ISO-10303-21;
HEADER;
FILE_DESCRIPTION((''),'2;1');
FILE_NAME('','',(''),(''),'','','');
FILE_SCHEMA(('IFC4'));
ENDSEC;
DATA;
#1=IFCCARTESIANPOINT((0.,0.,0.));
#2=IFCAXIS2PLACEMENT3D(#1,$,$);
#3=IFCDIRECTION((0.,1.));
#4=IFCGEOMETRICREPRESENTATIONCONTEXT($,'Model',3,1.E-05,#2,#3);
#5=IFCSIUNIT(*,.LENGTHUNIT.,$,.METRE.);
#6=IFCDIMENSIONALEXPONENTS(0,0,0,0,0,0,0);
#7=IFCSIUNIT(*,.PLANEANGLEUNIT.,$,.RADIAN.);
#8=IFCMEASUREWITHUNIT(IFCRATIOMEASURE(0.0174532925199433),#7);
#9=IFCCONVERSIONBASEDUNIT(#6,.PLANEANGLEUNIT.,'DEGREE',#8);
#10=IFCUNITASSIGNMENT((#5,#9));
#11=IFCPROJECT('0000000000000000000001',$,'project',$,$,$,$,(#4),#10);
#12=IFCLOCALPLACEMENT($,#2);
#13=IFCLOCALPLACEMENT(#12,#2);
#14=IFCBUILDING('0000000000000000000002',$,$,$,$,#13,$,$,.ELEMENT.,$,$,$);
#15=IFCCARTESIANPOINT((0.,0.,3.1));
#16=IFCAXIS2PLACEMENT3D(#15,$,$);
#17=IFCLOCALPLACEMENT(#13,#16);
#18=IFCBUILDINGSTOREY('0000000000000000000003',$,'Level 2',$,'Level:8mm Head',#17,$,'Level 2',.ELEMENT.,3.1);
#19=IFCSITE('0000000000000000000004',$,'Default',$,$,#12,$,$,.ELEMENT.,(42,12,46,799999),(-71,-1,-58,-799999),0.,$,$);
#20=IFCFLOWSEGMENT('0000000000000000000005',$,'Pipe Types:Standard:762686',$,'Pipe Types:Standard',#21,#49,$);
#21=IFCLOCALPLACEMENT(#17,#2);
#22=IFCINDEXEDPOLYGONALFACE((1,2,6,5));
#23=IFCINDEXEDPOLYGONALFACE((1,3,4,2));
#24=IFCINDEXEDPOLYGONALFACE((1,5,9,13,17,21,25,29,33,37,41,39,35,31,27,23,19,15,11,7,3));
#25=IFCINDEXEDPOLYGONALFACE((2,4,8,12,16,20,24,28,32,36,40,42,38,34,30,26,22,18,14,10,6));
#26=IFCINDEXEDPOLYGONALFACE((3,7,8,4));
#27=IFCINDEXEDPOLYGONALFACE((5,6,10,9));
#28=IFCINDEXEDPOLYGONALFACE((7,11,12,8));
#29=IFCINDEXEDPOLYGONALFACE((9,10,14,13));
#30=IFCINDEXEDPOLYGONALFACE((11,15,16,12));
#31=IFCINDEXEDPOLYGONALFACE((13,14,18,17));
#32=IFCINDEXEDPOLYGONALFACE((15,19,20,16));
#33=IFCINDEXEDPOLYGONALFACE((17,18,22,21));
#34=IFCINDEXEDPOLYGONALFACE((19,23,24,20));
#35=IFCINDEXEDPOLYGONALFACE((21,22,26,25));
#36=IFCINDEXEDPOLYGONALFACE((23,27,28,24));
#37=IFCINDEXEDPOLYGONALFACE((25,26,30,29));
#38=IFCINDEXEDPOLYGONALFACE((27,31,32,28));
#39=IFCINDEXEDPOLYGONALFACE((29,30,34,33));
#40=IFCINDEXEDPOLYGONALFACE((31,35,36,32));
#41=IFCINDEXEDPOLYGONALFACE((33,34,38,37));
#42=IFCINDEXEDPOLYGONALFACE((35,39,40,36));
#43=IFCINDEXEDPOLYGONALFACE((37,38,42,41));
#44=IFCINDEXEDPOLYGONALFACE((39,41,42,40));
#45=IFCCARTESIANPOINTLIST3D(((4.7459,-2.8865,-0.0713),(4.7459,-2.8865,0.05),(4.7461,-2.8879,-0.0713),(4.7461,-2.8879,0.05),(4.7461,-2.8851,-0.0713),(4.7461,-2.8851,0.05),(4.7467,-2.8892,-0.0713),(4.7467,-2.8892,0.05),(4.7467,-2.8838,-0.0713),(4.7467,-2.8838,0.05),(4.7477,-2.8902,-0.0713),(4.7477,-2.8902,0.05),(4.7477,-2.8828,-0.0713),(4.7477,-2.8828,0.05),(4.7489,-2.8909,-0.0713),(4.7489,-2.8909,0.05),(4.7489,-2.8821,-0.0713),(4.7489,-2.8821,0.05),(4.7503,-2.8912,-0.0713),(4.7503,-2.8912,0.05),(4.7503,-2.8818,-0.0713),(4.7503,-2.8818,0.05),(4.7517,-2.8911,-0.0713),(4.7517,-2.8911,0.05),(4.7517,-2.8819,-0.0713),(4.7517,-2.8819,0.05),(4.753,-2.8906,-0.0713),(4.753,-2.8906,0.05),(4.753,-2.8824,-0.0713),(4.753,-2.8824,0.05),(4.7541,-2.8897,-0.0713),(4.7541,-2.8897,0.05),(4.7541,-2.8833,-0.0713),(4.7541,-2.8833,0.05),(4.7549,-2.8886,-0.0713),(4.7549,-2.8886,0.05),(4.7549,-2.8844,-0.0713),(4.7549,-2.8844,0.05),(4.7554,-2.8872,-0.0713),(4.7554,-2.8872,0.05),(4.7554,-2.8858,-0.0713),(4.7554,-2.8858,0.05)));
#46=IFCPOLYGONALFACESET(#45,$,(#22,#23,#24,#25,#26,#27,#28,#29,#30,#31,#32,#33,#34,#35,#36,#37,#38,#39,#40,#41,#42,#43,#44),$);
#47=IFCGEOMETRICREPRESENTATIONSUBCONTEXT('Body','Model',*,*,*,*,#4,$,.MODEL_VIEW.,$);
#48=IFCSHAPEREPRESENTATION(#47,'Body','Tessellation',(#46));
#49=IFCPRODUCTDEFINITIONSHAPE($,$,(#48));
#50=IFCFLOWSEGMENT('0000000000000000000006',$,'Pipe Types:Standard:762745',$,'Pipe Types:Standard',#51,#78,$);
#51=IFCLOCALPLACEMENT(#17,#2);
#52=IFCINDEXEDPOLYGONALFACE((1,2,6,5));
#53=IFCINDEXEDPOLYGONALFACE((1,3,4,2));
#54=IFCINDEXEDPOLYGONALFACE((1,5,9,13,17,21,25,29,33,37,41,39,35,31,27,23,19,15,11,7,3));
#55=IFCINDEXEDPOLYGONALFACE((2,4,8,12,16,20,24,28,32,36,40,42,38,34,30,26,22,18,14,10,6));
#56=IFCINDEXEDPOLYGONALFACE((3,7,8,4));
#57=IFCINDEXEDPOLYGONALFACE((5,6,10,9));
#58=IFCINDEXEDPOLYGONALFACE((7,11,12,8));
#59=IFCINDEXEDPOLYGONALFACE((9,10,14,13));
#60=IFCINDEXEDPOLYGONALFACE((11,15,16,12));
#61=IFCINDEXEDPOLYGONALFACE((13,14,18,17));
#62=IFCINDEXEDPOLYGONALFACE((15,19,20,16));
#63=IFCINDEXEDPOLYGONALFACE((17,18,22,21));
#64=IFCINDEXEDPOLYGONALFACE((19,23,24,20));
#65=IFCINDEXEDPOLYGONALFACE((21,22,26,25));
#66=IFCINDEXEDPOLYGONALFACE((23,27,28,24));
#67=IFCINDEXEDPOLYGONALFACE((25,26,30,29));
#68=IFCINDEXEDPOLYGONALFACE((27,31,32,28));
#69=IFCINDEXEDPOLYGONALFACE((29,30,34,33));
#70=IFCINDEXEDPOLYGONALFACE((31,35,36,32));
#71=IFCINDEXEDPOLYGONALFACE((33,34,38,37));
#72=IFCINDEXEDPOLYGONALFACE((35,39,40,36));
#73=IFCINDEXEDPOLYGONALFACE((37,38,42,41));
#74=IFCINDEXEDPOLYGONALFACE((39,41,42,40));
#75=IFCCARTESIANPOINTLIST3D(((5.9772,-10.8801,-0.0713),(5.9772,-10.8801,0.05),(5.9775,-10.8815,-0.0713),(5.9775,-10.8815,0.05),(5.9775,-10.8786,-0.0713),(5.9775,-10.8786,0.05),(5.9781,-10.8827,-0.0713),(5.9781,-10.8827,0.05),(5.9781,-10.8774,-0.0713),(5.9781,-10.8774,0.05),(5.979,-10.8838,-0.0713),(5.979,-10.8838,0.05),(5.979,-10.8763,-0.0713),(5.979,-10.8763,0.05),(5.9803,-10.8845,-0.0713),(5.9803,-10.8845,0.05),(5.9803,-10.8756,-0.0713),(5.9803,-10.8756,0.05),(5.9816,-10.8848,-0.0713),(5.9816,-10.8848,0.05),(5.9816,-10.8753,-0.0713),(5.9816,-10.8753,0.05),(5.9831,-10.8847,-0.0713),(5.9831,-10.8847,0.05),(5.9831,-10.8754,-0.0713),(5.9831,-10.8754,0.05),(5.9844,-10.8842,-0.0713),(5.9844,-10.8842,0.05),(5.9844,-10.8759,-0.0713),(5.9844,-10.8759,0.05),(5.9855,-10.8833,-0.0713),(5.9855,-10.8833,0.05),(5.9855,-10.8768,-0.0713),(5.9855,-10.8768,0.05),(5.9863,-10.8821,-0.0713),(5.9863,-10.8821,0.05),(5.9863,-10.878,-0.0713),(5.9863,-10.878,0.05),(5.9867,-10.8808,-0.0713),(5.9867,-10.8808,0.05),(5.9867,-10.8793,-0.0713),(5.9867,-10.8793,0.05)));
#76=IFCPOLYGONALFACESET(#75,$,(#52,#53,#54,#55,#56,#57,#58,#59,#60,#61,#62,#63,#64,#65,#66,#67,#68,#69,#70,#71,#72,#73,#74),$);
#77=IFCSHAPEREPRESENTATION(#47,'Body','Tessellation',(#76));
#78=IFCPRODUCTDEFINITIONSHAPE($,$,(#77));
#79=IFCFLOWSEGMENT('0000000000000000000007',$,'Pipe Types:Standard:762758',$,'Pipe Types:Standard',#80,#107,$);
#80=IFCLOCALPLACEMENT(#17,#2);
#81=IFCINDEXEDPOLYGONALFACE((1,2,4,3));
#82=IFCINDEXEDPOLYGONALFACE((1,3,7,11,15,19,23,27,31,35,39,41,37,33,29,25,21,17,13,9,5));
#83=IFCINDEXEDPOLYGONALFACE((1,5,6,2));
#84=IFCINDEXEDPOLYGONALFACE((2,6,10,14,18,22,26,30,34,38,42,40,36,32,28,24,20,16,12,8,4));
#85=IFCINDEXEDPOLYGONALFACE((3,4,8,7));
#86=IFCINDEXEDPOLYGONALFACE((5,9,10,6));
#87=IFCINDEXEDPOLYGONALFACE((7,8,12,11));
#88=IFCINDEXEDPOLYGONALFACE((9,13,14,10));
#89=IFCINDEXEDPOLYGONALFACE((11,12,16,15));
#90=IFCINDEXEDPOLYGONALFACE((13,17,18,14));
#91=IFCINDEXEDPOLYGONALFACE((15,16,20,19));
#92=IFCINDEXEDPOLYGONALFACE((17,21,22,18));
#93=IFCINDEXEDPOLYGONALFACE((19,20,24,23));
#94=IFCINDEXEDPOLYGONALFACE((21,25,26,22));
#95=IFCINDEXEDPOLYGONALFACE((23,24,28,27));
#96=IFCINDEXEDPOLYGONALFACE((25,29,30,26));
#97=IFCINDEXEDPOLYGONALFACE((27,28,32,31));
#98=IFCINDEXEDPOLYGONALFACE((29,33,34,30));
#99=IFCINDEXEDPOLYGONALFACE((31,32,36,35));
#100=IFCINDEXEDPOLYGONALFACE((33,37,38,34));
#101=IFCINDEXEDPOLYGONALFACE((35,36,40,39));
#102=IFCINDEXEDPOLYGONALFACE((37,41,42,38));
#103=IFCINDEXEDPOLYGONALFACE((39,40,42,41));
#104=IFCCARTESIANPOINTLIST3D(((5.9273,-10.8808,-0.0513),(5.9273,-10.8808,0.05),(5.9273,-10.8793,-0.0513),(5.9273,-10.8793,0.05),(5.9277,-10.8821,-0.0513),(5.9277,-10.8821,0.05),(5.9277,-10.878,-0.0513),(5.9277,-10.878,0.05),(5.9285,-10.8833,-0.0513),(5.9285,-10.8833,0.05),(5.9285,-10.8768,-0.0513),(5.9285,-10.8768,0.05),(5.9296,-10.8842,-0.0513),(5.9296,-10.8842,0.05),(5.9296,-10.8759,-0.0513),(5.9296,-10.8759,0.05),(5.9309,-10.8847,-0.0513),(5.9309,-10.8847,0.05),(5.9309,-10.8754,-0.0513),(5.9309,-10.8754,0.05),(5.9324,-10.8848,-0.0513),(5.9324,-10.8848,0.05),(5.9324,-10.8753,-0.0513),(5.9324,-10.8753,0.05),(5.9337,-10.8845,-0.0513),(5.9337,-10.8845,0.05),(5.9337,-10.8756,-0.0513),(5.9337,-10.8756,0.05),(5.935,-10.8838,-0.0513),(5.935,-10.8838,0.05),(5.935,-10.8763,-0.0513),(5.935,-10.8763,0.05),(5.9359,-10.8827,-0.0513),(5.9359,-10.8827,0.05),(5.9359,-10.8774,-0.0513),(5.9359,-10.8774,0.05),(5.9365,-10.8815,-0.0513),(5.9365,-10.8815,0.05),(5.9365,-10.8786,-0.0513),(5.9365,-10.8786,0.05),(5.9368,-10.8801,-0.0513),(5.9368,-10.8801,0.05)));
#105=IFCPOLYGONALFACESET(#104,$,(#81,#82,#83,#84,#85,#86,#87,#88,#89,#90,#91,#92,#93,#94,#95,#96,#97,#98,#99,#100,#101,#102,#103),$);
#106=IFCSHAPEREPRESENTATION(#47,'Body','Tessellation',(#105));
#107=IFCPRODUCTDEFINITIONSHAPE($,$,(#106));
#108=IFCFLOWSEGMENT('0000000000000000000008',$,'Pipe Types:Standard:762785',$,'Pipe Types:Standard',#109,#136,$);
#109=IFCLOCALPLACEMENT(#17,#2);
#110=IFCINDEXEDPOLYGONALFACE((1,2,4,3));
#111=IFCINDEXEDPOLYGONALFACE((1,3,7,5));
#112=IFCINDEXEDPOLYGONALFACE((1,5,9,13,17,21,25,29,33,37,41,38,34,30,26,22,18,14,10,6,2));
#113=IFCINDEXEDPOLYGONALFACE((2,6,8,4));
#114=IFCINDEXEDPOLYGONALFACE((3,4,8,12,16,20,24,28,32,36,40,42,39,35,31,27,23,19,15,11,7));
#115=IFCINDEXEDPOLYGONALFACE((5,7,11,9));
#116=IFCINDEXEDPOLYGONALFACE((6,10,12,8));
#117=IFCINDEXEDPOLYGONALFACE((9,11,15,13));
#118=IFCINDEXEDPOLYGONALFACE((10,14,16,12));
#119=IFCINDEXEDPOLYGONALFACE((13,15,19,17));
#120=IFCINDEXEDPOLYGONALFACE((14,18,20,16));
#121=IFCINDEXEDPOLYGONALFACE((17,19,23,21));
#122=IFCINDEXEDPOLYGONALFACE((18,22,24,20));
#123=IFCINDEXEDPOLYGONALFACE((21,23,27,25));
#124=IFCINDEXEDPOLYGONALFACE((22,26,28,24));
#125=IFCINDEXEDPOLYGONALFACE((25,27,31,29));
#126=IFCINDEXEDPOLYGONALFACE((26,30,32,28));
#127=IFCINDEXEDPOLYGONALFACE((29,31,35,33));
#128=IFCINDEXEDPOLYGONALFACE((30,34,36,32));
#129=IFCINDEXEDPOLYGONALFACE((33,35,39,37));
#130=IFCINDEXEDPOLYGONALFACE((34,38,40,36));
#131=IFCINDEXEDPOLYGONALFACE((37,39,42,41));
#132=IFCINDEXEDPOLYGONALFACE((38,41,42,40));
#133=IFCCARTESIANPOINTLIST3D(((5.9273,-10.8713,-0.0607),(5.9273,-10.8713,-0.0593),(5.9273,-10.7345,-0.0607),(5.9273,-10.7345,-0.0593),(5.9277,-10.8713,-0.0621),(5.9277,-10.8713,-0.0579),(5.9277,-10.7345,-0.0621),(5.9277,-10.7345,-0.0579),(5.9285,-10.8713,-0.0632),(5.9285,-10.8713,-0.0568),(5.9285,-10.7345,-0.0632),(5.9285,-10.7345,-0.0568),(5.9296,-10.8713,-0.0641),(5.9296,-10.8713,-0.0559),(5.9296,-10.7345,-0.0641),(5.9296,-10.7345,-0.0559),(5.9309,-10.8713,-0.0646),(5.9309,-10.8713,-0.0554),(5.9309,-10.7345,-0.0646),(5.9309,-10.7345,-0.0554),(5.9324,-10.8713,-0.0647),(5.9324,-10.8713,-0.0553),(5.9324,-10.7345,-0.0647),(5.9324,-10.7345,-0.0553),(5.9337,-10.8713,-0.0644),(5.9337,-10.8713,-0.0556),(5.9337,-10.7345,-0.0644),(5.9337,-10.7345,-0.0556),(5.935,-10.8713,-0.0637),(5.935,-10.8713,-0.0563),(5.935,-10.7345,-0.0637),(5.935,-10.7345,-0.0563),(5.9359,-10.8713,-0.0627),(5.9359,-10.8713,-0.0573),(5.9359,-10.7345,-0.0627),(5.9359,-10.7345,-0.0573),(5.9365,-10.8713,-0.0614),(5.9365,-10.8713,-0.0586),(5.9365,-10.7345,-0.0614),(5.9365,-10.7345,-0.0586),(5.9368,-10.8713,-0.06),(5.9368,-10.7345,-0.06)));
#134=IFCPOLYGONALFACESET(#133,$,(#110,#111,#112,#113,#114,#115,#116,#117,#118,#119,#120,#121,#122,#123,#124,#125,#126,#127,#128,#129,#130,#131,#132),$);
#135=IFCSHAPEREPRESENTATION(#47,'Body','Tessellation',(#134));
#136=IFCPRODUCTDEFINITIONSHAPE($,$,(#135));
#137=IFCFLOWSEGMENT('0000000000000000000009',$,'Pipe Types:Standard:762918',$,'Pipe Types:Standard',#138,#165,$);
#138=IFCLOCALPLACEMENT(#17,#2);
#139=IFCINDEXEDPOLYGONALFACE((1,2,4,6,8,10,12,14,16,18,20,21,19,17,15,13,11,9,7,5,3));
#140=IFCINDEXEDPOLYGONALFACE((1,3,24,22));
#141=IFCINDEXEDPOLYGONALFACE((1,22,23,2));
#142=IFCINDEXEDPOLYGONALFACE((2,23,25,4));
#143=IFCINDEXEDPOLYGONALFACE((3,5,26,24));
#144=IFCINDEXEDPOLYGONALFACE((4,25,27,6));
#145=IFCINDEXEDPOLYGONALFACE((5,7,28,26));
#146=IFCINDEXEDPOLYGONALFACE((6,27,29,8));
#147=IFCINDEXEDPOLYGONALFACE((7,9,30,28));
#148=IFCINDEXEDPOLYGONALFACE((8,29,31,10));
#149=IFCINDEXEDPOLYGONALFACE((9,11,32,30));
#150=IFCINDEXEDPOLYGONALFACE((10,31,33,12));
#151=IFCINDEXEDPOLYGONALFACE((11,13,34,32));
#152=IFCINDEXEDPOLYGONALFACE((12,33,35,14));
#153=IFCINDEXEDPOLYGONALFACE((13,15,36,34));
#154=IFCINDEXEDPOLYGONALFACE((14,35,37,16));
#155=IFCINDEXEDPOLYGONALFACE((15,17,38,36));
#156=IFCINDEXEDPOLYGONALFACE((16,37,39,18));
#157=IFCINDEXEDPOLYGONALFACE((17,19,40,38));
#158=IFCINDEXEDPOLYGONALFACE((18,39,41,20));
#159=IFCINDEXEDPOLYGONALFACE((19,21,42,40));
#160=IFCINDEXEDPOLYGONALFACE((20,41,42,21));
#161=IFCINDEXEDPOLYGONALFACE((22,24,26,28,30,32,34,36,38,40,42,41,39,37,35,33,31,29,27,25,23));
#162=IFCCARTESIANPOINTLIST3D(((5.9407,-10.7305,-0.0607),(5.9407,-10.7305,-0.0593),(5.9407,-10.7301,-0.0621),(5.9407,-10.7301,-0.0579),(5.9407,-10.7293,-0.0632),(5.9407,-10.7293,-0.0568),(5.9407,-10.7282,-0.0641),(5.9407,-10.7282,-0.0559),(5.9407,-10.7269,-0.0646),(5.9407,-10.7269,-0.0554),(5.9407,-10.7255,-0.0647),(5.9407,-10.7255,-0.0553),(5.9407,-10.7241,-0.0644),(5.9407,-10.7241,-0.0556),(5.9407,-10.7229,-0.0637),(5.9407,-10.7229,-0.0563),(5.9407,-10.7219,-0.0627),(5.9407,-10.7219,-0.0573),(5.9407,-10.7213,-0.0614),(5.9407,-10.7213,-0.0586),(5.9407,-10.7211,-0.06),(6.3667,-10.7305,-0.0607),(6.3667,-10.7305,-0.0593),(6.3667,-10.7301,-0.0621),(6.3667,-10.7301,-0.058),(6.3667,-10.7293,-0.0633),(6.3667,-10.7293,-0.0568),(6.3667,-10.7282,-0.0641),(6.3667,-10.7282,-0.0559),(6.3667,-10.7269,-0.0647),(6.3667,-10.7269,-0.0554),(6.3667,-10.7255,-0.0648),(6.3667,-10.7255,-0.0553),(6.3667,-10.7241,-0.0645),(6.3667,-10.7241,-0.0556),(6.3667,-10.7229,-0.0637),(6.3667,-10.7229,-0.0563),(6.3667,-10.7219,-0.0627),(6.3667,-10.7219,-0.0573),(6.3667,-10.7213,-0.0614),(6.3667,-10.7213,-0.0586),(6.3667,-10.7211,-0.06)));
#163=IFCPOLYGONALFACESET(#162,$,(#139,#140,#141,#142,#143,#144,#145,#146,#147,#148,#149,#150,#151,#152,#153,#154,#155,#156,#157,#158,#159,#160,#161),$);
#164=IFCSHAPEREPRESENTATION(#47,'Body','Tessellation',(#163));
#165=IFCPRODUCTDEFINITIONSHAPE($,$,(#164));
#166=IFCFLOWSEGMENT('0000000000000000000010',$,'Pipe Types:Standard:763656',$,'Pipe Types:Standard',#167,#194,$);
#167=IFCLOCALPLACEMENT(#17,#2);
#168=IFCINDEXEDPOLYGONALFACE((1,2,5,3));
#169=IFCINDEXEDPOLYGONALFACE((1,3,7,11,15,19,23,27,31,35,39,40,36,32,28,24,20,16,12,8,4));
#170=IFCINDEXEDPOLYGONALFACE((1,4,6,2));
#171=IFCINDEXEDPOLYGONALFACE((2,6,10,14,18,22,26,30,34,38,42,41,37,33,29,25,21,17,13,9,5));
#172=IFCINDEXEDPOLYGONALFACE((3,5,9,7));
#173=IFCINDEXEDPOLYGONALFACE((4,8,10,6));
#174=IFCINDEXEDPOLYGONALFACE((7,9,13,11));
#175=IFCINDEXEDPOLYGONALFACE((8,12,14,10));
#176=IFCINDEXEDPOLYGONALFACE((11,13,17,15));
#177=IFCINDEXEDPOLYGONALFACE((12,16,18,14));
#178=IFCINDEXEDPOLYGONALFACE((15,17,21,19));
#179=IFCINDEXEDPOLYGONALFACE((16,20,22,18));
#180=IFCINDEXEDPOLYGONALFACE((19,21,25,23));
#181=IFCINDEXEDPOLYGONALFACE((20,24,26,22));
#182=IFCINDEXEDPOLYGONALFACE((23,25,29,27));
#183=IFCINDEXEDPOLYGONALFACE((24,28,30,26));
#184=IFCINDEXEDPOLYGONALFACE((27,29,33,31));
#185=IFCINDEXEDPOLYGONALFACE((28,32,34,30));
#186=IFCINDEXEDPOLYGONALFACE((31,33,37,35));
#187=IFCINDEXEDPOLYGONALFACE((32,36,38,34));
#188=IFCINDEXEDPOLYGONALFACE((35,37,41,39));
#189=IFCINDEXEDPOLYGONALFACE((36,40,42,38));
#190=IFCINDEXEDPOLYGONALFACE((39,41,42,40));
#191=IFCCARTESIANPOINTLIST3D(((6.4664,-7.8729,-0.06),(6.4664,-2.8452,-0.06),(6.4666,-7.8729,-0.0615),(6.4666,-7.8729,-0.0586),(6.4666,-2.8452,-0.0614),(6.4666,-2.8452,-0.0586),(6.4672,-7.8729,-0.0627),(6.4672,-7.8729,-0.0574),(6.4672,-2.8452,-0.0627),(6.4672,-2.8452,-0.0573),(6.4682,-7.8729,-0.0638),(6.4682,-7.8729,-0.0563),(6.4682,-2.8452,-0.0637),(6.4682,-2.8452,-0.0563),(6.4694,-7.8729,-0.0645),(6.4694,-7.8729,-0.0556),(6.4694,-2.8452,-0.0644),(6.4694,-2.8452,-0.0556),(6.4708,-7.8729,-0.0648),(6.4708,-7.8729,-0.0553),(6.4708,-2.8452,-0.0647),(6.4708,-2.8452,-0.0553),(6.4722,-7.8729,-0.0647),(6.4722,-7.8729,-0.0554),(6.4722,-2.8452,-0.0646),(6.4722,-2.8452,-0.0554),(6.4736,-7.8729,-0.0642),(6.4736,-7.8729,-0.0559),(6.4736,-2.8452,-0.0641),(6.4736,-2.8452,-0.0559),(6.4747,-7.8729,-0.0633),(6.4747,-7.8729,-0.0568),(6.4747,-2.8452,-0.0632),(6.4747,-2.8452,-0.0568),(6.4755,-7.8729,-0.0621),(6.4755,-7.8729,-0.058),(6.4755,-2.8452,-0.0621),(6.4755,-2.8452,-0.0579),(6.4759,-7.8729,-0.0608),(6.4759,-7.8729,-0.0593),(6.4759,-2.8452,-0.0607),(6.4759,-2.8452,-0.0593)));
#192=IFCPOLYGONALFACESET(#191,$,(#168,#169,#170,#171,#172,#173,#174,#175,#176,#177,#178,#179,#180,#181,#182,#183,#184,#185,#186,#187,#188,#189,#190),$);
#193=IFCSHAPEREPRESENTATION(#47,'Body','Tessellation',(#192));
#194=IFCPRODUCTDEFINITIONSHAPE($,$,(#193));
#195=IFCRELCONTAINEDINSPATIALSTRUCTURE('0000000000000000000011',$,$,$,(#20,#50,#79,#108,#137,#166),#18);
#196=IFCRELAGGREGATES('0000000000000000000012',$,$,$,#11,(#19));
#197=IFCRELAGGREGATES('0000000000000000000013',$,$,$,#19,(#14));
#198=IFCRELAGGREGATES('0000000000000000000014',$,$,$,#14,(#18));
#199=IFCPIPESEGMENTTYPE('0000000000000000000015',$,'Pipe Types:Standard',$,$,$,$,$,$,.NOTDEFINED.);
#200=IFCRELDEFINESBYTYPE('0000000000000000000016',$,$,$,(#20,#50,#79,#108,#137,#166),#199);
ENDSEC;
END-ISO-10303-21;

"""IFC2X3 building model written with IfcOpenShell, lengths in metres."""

from ifc_helpers import new_model, entity, si_unit, converted_unit, direction, frame, frame_2d, origin, origin_2d_with_axis, place, context, subcontext, project, spatial, circle, extrude, type_object, element, save


model = new_model("IFC2X3")

# Units and contexts
model_context = context("Model", 3, precision=1e-05, world=origin(), true_north=direction((0.0, 1.0)))
body_context = subcontext(model_context, "Body", "Model", "MODEL_VIEW")
ifc_project = project(units=[si_unit("LENGTHUNIT", "METRE"), converted_unit("PLANEANGLEUNIT", "DEGREE", entity("IfcRatioMeasure", 0.0174532925199433), si_unit("PLANEANGLEUNIT", "RADIAN"), dimensions=[0, 0, 0, 0, 0, 0, 0])], contexts=[model_context])

# Site, building, storey
site_placement = place(None, origin())
site = spatial("IfcSite", under=ifc_project, at=site_placement, Name="Default", CompositionType="ELEMENT", RefLatitude=(42, 12, 46, 799999), RefLongitude=(-71, -1, -58, -799999), RefElevation=0.0)
building_placement = place(site_placement, origin())
building = spatial("IfcBuilding", under=site, at=building_placement, CompositionType="ELEMENT")
storey_placement = place(building_placement, frame((0.0, 0.0, 3.1)))
storey = spatial("IfcBuildingStorey", under=building, at=storey_placement, Name="Level 2", ObjectType="Level:8mm Head", LongName="Level 2", CompositionType="ELEMENT", Elevation=3.1)

# Flow segments
pipe_segment_type = type_object("IfcPipeSegmentType", Name="Pipe Types:Standard", PredefinedType="NOTDEFINED")
flow_segment_1_placement = place(storey_placement, origin())
element("IfcFlowSegment", 1, at=flow_segment_1_placement, inside=storey, type_object=pipe_segment_type, Name="Pipe Types:Standard:762686", ObjectType="Pipe Types:Standard", context=body_context, shape_type="SweptSolid", body=[
    extrude(circle(Radius=0.0048, at=frame_2d((0.0, 0.0), x_axis=(1.0, 0.0))), frame((4.7506, -2.8865, -0.0713), z_axis=(0.0, 0.0, 1.0), x_axis=(-1.0, 0.0, 0.0)), (0.0, 0.0, 1.0), 0.1213),
])
flow_segment_2_placement = place(storey_placement, origin())
element("IfcFlowSegment", 2, at=flow_segment_2_placement, inside=storey, type_object=pipe_segment_type, Name="Pipe Types:Standard:762745", ObjectType="Pipe Types:Standard", context=body_context, shape_type="SweptSolid", body=[
    extrude(circle(Radius=0.0048, at=origin_2d_with_axis()), frame((5.982, -10.8801, -0.0713), z_axis=(0.0, 0.0, 1.0), x_axis=(-1.0, 0.0, 0.0)), (0.0, 0.0, 1.0), 0.1213),
])
flow_segment_3_placement = place(storey_placement, origin())
element("IfcFlowSegment", 3, at=flow_segment_3_placement, inside=storey, type_object=pipe_segment_type, Name="Pipe Types:Standard:762758", ObjectType="Pipe Types:Standard", context=body_context, shape_type="SweptSolid", body=[
    extrude(circle(Radius=0.0048, at=origin_2d_with_axis()), frame((5.932, -10.8801, -0.0513)), (0.0, 0.0, 1.0), 0.1013),
])
flow_segment_4_placement = place(storey_placement, origin())
element("IfcFlowSegment", 4, at=flow_segment_4_placement, inside=storey, type_object=pipe_segment_type, Name="Pipe Types:Standard:762785", ObjectType="Pipe Types:Standard", context=body_context, shape_type="SweptSolid", body=[
    extrude(circle(Radius=0.0048, at=origin_2d_with_axis()), frame((5.932, -10.8713, -0.06), z_axis=(0.0, 1.0, 0.0), x_axis=(1.0, 0.0, 0.0)), (0.0, 0.0, 1.0), 0.1368),
])
flow_segment_5_placement = place(storey_placement, origin())
element("IfcFlowSegment", 5, at=flow_segment_5_placement, inside=storey, type_object=pipe_segment_type, Name="Pipe Types:Standard:762918", ObjectType="Pipe Types:Standard", context=body_context, shape_type="SweptSolid", body=[
    extrude(circle(Radius=0.0048, at=frame_2d((0.0, 0.0), x_axis=(1.0, 0.0))), frame((6.3667, -10.7258, -0.06), z_axis=(-1.0, 0.0, 0.000059), x_axis=(0.0, 1.0, 0.0)), (0.0, 0.0, 1.0), 0.426),
])
flow_segment_6_placement = place(storey_placement, origin())
element("IfcFlowSegment", 6, at=flow_segment_6_placement, inside=storey, type_object=pipe_segment_type, Name="Pipe Types:Standard:763656", ObjectType="Pipe Types:Standard", context=body_context, shape_type="SweptSolid", body=[
    extrude(circle(Radius=0.0048, at=frame_2d((0.0, 0.0), x_axis=(1.0, 0.0))), frame((6.4712, -7.8729, -0.06), z_axis=(0.0, 1.0, 0.00001), x_axis=(-1.0, 0.0, 0.0)), (0.0, 0.0, 1.0), 5.0277),
])

save(model, "model.ifc")
